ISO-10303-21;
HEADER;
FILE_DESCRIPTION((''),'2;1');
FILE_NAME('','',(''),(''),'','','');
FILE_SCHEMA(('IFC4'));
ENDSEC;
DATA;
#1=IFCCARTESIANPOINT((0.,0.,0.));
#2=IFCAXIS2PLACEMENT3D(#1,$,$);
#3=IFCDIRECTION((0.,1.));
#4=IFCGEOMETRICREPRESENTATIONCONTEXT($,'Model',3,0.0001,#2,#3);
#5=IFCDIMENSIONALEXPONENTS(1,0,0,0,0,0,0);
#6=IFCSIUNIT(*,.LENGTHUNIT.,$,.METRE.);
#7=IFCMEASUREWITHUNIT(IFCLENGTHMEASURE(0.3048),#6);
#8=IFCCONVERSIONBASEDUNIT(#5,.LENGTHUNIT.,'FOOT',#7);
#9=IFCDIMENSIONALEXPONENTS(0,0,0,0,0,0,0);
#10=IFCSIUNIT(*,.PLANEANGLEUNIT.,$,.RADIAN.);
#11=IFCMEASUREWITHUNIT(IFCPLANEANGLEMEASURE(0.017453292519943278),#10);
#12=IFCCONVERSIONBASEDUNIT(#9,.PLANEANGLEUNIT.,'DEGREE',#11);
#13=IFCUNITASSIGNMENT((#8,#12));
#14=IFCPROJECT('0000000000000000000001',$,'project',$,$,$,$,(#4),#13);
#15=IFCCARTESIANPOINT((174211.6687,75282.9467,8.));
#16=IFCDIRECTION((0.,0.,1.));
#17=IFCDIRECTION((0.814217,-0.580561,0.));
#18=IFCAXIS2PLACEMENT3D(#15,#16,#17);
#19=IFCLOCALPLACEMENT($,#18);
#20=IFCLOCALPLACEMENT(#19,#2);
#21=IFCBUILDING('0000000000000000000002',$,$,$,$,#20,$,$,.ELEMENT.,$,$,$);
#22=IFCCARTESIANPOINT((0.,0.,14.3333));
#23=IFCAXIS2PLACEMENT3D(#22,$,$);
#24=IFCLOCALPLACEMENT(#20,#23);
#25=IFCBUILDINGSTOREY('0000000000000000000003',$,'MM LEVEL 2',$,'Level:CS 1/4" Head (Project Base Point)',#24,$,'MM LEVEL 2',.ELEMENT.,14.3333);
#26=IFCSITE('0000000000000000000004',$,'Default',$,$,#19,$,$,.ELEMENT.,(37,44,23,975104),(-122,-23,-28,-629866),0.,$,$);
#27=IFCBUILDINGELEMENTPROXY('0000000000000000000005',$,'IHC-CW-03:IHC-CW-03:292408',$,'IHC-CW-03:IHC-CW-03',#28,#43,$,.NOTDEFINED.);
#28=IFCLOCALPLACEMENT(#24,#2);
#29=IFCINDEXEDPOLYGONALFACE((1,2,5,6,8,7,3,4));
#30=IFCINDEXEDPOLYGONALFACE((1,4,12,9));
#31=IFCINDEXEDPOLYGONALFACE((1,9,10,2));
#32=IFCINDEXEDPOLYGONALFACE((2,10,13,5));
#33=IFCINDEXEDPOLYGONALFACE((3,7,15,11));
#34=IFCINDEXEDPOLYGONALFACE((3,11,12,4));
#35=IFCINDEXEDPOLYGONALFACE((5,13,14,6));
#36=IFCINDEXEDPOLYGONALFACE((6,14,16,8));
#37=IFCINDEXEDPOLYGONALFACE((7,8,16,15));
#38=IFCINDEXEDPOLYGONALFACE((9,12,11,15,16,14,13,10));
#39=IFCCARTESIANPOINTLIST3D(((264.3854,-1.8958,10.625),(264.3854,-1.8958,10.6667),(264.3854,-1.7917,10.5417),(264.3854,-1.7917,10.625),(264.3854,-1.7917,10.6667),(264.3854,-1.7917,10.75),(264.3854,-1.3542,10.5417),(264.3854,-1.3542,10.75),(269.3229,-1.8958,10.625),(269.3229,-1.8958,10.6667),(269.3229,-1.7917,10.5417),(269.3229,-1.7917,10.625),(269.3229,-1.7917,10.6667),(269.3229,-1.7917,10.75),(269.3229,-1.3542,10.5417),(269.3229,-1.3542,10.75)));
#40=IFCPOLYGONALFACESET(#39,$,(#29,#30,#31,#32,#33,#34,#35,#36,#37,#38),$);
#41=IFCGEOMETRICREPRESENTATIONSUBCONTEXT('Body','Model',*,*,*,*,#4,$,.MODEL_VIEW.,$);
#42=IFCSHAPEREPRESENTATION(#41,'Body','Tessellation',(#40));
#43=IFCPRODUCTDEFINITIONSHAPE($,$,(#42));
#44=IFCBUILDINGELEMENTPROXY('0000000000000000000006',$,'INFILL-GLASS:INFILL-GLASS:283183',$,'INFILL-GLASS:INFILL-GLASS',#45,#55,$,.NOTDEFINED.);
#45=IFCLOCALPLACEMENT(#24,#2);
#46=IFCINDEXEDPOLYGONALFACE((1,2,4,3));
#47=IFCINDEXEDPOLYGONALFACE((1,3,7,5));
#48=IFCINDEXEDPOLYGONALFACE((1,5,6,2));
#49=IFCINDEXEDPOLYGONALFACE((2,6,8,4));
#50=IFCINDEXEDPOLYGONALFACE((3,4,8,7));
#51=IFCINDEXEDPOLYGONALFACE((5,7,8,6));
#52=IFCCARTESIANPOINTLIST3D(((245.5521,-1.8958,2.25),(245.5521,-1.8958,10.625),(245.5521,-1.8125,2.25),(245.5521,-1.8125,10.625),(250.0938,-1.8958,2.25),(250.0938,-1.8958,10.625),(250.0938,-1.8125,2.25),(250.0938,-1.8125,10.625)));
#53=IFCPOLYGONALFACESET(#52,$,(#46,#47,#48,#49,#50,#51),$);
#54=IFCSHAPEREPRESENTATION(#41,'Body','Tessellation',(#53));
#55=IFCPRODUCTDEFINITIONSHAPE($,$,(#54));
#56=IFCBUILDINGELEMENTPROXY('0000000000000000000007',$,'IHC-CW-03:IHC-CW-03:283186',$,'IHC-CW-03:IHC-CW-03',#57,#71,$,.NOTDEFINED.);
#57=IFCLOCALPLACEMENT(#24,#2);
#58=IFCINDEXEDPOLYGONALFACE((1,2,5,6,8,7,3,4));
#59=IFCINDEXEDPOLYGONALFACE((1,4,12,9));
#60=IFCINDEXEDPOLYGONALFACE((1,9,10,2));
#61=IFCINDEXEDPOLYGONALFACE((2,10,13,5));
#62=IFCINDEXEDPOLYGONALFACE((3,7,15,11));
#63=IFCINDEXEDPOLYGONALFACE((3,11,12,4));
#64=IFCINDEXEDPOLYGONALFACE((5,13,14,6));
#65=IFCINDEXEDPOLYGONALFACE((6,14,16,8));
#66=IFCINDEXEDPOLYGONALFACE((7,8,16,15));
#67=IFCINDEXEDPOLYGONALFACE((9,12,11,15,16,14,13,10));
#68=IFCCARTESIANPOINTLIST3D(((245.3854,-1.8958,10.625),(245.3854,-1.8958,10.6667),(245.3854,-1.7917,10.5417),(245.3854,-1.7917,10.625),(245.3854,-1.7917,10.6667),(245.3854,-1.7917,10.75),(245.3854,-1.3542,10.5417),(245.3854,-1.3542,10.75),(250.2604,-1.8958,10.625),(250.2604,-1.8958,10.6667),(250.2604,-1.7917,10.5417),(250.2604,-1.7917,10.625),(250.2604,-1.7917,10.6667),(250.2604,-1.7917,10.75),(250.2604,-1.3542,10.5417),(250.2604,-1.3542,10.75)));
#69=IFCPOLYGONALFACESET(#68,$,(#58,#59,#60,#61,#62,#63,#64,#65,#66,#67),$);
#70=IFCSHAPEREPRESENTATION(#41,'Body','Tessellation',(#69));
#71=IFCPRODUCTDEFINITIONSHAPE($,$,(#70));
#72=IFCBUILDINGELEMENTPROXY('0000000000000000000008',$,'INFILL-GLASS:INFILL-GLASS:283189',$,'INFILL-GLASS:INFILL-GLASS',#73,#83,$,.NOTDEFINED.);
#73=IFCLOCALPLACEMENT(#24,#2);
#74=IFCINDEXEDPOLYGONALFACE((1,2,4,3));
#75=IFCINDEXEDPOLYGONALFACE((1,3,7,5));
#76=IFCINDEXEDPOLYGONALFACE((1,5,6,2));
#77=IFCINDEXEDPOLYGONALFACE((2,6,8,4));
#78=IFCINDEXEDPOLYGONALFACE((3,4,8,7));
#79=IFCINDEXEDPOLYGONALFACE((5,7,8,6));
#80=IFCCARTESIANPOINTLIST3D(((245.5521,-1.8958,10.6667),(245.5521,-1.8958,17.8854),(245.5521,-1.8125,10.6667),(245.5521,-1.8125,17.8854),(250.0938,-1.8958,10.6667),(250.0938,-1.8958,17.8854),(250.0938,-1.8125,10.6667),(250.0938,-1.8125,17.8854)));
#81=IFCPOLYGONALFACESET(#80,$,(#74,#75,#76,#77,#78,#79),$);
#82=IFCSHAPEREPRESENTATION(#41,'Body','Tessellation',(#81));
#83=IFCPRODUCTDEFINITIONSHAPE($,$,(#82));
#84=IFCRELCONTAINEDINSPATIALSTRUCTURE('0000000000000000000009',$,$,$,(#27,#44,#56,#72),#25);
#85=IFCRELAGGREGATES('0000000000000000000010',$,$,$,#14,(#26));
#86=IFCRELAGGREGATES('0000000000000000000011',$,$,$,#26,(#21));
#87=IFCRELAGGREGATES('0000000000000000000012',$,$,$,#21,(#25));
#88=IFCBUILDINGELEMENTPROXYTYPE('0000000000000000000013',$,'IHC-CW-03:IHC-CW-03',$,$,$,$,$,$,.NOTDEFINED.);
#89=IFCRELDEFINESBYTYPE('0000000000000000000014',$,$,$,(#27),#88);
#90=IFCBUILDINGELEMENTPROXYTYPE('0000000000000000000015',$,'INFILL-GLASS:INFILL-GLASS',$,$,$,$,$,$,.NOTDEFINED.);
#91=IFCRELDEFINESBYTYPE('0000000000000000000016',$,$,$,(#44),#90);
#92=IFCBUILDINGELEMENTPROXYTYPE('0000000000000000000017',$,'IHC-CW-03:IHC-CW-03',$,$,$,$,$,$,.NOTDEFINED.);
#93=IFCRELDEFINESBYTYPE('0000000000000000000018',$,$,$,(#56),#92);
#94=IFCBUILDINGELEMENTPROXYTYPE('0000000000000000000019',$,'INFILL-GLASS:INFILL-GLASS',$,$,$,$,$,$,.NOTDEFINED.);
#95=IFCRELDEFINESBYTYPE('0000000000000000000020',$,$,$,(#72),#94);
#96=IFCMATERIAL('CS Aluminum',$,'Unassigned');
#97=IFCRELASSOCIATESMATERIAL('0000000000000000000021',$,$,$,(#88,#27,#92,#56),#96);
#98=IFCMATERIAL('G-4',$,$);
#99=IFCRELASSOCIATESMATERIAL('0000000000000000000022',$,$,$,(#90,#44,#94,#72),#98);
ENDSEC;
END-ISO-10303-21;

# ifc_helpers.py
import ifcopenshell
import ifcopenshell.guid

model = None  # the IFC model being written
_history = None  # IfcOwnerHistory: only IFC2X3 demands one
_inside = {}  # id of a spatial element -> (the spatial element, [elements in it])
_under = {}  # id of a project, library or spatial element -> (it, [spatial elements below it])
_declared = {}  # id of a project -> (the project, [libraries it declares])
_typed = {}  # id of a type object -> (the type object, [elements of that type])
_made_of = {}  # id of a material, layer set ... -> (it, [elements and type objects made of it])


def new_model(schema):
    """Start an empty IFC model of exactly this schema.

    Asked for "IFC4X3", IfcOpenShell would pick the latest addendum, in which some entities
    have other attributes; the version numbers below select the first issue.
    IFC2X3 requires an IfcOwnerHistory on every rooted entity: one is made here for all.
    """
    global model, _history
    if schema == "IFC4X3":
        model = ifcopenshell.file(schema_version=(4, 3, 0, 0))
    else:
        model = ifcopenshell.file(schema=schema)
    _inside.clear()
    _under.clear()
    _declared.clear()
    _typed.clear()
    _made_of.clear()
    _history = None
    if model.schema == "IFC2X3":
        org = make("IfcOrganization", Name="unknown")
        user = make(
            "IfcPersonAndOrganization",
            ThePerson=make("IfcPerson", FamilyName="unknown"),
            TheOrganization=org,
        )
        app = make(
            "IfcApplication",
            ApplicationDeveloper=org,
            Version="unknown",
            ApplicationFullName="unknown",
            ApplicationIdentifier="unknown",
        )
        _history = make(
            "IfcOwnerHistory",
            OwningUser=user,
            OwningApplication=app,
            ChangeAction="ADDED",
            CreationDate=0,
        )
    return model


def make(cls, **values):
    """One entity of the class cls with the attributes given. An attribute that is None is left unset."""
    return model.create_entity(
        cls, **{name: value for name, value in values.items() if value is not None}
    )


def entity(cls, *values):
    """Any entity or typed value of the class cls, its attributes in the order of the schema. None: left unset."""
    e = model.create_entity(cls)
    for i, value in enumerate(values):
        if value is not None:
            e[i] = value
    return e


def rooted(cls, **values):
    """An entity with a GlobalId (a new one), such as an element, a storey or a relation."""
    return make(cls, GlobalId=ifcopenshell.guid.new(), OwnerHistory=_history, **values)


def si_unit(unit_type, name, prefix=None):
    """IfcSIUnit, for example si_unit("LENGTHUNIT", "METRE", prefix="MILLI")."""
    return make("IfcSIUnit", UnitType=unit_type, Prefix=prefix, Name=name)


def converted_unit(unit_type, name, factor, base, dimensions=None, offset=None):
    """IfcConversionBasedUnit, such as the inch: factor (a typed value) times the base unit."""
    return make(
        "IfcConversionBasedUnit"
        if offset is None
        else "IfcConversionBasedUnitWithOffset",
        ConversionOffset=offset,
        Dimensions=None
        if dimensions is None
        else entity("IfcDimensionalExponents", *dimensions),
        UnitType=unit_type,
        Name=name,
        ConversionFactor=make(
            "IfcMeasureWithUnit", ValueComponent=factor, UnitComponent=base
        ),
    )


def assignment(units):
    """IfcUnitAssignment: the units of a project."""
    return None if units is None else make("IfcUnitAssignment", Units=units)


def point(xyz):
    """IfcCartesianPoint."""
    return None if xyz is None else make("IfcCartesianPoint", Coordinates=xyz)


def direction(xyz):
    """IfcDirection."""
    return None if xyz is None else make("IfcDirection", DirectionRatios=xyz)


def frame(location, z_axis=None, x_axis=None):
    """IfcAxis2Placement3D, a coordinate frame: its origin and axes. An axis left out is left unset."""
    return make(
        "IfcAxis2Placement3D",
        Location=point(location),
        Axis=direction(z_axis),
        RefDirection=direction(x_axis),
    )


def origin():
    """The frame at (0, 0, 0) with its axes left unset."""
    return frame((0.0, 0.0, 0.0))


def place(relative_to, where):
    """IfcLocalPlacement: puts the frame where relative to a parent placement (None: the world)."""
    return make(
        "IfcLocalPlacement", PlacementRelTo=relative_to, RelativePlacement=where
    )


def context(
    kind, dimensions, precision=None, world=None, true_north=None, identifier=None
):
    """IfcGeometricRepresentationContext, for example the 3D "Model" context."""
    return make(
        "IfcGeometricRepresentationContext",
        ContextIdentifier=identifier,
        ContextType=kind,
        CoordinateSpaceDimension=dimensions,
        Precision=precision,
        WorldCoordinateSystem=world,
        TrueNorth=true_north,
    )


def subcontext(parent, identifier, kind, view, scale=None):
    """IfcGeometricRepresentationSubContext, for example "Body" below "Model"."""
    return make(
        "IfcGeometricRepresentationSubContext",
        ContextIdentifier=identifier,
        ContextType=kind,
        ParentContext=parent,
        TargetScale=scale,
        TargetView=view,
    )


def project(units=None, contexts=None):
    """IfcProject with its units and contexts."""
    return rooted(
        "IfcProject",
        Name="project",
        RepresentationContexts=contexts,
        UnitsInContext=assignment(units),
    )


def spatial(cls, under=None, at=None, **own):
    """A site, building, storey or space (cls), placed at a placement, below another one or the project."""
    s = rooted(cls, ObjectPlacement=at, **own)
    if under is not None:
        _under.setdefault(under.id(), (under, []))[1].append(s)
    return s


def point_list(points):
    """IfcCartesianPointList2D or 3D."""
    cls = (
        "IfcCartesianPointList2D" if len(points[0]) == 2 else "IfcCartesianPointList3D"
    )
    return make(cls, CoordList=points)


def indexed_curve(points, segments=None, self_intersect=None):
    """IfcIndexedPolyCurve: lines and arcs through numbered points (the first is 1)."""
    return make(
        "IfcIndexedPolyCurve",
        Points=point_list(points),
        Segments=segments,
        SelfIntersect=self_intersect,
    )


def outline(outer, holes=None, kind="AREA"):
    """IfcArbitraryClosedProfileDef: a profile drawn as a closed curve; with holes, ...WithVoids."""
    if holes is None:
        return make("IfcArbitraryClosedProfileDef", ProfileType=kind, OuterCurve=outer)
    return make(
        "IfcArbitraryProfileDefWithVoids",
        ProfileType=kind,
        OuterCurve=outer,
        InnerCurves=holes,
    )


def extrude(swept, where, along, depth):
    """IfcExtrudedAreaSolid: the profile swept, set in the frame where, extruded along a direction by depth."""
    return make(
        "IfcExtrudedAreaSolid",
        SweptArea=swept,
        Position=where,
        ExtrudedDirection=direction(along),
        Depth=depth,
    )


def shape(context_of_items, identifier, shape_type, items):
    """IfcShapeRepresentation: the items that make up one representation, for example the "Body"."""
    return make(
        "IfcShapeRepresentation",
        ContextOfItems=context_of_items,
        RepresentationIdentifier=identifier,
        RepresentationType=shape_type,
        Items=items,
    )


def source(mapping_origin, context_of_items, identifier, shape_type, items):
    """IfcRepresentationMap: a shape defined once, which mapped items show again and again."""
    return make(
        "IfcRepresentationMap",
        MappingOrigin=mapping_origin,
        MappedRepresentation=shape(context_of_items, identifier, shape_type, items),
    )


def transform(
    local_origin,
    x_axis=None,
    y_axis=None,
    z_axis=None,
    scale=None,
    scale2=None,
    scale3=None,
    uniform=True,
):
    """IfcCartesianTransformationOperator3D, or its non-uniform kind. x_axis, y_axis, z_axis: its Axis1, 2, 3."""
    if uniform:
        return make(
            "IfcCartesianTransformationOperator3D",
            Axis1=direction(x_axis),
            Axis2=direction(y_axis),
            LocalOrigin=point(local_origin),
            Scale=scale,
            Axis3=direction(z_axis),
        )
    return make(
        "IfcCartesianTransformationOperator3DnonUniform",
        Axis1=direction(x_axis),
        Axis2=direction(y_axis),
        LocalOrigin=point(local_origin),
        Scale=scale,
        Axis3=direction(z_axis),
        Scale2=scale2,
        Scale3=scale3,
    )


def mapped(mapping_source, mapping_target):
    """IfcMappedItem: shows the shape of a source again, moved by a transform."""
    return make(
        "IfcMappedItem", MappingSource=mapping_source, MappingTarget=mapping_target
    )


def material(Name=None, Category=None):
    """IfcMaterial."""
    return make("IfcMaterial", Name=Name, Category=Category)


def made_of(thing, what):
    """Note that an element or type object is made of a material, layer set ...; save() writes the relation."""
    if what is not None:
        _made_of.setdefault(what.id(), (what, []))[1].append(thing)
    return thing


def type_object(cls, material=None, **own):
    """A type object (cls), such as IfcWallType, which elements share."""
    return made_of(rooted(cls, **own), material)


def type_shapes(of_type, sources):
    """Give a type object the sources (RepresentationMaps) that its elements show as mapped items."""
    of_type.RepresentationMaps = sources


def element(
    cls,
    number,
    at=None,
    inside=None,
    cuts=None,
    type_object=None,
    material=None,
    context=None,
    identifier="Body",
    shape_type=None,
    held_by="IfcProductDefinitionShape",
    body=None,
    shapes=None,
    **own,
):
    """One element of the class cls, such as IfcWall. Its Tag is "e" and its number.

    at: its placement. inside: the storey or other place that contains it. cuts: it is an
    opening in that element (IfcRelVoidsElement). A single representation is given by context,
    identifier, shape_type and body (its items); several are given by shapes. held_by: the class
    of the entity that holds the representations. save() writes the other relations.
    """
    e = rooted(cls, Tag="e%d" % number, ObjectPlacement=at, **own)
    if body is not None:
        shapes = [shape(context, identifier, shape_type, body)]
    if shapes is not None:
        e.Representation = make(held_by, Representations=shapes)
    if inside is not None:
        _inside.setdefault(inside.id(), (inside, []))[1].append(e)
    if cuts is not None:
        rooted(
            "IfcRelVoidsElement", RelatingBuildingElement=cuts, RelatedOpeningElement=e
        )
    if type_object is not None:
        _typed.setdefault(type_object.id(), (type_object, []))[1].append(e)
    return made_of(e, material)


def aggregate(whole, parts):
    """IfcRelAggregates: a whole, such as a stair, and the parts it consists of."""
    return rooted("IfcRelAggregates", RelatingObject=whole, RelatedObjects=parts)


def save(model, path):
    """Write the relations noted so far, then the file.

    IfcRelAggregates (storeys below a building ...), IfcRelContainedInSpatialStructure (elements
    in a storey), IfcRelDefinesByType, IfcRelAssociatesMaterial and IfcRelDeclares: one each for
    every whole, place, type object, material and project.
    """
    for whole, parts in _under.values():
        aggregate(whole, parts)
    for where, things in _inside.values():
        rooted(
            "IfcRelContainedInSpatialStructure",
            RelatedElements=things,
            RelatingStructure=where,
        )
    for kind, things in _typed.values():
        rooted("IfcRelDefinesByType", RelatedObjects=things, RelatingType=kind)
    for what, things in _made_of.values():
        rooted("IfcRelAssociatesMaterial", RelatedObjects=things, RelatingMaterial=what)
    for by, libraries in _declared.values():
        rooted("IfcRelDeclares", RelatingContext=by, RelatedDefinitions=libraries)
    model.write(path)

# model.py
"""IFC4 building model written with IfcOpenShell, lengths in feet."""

from ifc_helpers import new_model, entity, si_unit, converted_unit, direction, frame, origin, place, context, subcontext, project, spatial, indexed_curve, outline, extrude, source, transform, mapped, material, type_object, type_shapes, element, save


model = new_model("IFC4")

# Units and contexts
model_context = context("Model", 3, precision=0.0001, world=origin(), true_north=direction((0.0, 1.0)))
body_context = subcontext(model_context, "Body", "Model", "MODEL_VIEW")
ifc_project = project(units=[converted_unit("LENGTHUNIT", "FOOT", entity("IfcLengthMeasure", 0.3048), si_unit("LENGTHUNIT", "METRE"), dimensions=[1, 0, 0, 0, 0, 0, 0]), converted_unit("PLANEANGLEUNIT", "DEGREE", entity("IfcPlaneAngleMeasure", 0.017453292519943278), si_unit("PLANEANGLEUNIT", "RADIAN"), dimensions=[0, 0, 0, 0, 0, 0, 0])], contexts=[model_context])

# Site, building, storey
site_placement = place(None, frame((174211.6687, 75282.9467, 8.0), z_axis=(0.0, 0.0, 1.0), x_axis=(0.814217, -0.580561, 0.0)))
site = spatial("IfcSite", under=ifc_project, at=site_placement, Name="Default", CompositionType="ELEMENT", RefLatitude=(37, 44, 23, 975104), RefLongitude=(-122, -23, -28, -629866), RefElevation=0.0)
building_placement = place(site_placement, origin())
building = spatial("IfcBuilding", under=site, at=building_placement, CompositionType="ELEMENT")
storey_placement = place(building_placement, frame((0.0, 0.0, 14.3333)))
storey = spatial("IfcBuildingStorey", under=building, at=storey_placement, Name="MM LEVEL 2", ObjectType="Level:CS 1/4\" Head (Project Base Point)", LongName="MM LEVEL 2", CompositionType="ELEMENT", Elevation=14.3333)

# Shared definitions
ifc_material_1 = material(Name="CS Aluminum", Category="Unassigned")

# Building element proxies
building_element_proxy_type_1 = type_object("IfcBuildingElementProxyType", Name="IHC-CW-03:IHC-CW-03", PredefinedType="NOTDEFINED", material=ifc_material_1)
shared_shape_1 = source(origin(), body_context, "Body", "SweptSolid", [
    extrude(outline(indexed_curve([(-0.0208, -0.1875), (0.0208, -0.1875), (0.0208, -0.0833), (0.1042, -0.0833), (0.1042, 0.3542), (-0.1042, 0.3542), (-0.1042, -0.0833), (-0.0208, -0.0833), (-0.0208, -0.1875)], self_intersect=False)), frame((-2.4688, -0.2708, -0.1042), z_axis=(1.0, 0.0, 0.0), x_axis=(0.0, 0.0, 1.0)), (0.0, 0.0, 1.0), 4.9375),
])
type_shapes(building_element_proxy_type_1, [shared_shape_1])
proxy_1_placement = place(storey_placement, frame((266.8542, -1.9792, 10.75), z_axis=(0.0, 0.0, 1.0), x_axis=(-1.0, 0.0, 0.0)))
element("IfcBuildingElementProxy", 1, at=proxy_1_placement, inside=storey, type_object=building_element_proxy_type_1, material=ifc_material_1, Name="IHC-CW-03:IHC-CW-03:292408", ObjectType="IHC-CW-03:IHC-CW-03", PredefinedType="NOTDEFINED", context=body_context, shape_type="MappedRepresentation", body=[
    mapped(shared_shape_1, transform((0.0, 0.0, 0.0), scale=1.0)),
])
ifc_material_2 = material(Name="G-4")
building_element_proxy_type_2 = type_object("IfcBuildingElementProxyType", Name="INFILL-GLASS:INFILL-GLASS", PredefinedType="NOTDEFINED", material=ifc_material_2)
shared_shape_2 = source(origin(), body_context, "Body", "SweptSolid", [
    extrude(outline(indexed_curve([(-0.0417, -2.2708), (0.0417, -2.2708), (0.0417, 2.2708), (-0.0417, 2.2708), (-0.0417, -2.2708)], self_intersect=False)), frame((0.0, 0.125, 0.1667), z_axis=(0.0, 0.0, 1.0), x_axis=(0.0, 1.0, 0.0)), (0.0, 0.0, 1.0), 8.375),
])
type_shapes(building_element_proxy_type_2, [shared_shape_2])
proxy_2_placement = place(storey_placement, frame((247.8229, -1.9792, 2.0833)))
element("IfcBuildingElementProxy", 2, at=proxy_2_placement, inside=storey, type_object=building_element_proxy_type_2, material=ifc_material_2, Name="INFILL-GLASS:INFILL-GLASS:283183", ObjectType="INFILL-GLASS:INFILL-GLASS", PredefinedType="NOTDEFINED", context=body_context, shape_type="MappedRepresentation", body=[
    mapped(shared_shape_2, transform((0.0, 0.0, 0.0), scale=1.0)),
])
building_element_proxy_type_3 = type_object("IfcBuildingElementProxyType", Name="IHC-CW-03:IHC-CW-03", PredefinedType="NOTDEFINED", material=ifc_material_1)
shared_shape_3 = source(origin(), body_context, "Body", "SweptSolid", [
    extrude(outline(indexed_curve([(-0.0208, -0.1875), (0.0208, -0.1875), (0.0208, -0.0833), (0.1042, -0.0833), (0.1042, 0.3542), (-0.1042, 0.3542), (-0.1042, -0.0833), (-0.0208, -0.0833), (-0.0208, -0.1875)], self_intersect=False)), frame((-2.4375, -0.2708, -0.1042), z_axis=(1.0, 0.0, 0.0), x_axis=(0.0, 0.0, 1.0)), (0.0, 0.0, 1.0), 4.875),
])
type_shapes(building_element_proxy_type_3, [shared_shape_3])
proxy_3_placement = place(storey_placement, frame((247.8229, -1.9792, 10.75), z_axis=(0.0, 0.0, 1.0), x_axis=(-1.0, 0.0, 0.0)))
element("IfcBuildingElementProxy", 3, at=proxy_3_placement, inside=storey, type_object=building_element_proxy_type_3, material=ifc_material_1, Name="IHC-CW-03:IHC-CW-03:283186", ObjectType="IHC-CW-03:IHC-CW-03", PredefinedType="NOTDEFINED", context=body_context, shape_type="MappedRepresentation", body=[
    mapped(shared_shape_3, transform((0.0, 0.0, 0.0), scale=1.0)),
])
building_element_proxy_type_4 = type_object("IfcBuildingElementProxyType", Name="INFILL-GLASS:INFILL-GLASS", PredefinedType="NOTDEFINED", material=ifc_material_2)
shared_shape_4 = source(origin(), body_context, "Body", "SweptSolid", [
    extrude(outline(indexed_curve([(-0.0417, -2.2708), (0.0417, -2.2708), (0.0417, 2.2708), (-0.0417, 2.2708), (-0.0417, -2.2708)], self_intersect=False)), frame((0.0, 0.125, -0.0833), z_axis=(0.0, 0.0, 1.0), x_axis=(0.0, 1.0, 0.0)), (0.0, 0.0, 1.0), 7.2187),
])
type_shapes(building_element_proxy_type_4, [shared_shape_4])
proxy_4_placement = place(storey_placement, frame((247.8229, -1.9792, 10.75)))
element("IfcBuildingElementProxy", 4, at=proxy_4_placement, inside=storey, type_object=building_element_proxy_type_4, material=ifc_material_2, Name="INFILL-GLASS:INFILL-GLASS:283189", ObjectType="INFILL-GLASS:INFILL-GLASS", PredefinedType="NOTDEFINED", context=body_context, shape_type="MappedRepresentation", body=[
    mapped(shared_shape_4, transform((0.0, 0.0, 0.0), scale=1.0)),
])

save(model, "model.ifc")
